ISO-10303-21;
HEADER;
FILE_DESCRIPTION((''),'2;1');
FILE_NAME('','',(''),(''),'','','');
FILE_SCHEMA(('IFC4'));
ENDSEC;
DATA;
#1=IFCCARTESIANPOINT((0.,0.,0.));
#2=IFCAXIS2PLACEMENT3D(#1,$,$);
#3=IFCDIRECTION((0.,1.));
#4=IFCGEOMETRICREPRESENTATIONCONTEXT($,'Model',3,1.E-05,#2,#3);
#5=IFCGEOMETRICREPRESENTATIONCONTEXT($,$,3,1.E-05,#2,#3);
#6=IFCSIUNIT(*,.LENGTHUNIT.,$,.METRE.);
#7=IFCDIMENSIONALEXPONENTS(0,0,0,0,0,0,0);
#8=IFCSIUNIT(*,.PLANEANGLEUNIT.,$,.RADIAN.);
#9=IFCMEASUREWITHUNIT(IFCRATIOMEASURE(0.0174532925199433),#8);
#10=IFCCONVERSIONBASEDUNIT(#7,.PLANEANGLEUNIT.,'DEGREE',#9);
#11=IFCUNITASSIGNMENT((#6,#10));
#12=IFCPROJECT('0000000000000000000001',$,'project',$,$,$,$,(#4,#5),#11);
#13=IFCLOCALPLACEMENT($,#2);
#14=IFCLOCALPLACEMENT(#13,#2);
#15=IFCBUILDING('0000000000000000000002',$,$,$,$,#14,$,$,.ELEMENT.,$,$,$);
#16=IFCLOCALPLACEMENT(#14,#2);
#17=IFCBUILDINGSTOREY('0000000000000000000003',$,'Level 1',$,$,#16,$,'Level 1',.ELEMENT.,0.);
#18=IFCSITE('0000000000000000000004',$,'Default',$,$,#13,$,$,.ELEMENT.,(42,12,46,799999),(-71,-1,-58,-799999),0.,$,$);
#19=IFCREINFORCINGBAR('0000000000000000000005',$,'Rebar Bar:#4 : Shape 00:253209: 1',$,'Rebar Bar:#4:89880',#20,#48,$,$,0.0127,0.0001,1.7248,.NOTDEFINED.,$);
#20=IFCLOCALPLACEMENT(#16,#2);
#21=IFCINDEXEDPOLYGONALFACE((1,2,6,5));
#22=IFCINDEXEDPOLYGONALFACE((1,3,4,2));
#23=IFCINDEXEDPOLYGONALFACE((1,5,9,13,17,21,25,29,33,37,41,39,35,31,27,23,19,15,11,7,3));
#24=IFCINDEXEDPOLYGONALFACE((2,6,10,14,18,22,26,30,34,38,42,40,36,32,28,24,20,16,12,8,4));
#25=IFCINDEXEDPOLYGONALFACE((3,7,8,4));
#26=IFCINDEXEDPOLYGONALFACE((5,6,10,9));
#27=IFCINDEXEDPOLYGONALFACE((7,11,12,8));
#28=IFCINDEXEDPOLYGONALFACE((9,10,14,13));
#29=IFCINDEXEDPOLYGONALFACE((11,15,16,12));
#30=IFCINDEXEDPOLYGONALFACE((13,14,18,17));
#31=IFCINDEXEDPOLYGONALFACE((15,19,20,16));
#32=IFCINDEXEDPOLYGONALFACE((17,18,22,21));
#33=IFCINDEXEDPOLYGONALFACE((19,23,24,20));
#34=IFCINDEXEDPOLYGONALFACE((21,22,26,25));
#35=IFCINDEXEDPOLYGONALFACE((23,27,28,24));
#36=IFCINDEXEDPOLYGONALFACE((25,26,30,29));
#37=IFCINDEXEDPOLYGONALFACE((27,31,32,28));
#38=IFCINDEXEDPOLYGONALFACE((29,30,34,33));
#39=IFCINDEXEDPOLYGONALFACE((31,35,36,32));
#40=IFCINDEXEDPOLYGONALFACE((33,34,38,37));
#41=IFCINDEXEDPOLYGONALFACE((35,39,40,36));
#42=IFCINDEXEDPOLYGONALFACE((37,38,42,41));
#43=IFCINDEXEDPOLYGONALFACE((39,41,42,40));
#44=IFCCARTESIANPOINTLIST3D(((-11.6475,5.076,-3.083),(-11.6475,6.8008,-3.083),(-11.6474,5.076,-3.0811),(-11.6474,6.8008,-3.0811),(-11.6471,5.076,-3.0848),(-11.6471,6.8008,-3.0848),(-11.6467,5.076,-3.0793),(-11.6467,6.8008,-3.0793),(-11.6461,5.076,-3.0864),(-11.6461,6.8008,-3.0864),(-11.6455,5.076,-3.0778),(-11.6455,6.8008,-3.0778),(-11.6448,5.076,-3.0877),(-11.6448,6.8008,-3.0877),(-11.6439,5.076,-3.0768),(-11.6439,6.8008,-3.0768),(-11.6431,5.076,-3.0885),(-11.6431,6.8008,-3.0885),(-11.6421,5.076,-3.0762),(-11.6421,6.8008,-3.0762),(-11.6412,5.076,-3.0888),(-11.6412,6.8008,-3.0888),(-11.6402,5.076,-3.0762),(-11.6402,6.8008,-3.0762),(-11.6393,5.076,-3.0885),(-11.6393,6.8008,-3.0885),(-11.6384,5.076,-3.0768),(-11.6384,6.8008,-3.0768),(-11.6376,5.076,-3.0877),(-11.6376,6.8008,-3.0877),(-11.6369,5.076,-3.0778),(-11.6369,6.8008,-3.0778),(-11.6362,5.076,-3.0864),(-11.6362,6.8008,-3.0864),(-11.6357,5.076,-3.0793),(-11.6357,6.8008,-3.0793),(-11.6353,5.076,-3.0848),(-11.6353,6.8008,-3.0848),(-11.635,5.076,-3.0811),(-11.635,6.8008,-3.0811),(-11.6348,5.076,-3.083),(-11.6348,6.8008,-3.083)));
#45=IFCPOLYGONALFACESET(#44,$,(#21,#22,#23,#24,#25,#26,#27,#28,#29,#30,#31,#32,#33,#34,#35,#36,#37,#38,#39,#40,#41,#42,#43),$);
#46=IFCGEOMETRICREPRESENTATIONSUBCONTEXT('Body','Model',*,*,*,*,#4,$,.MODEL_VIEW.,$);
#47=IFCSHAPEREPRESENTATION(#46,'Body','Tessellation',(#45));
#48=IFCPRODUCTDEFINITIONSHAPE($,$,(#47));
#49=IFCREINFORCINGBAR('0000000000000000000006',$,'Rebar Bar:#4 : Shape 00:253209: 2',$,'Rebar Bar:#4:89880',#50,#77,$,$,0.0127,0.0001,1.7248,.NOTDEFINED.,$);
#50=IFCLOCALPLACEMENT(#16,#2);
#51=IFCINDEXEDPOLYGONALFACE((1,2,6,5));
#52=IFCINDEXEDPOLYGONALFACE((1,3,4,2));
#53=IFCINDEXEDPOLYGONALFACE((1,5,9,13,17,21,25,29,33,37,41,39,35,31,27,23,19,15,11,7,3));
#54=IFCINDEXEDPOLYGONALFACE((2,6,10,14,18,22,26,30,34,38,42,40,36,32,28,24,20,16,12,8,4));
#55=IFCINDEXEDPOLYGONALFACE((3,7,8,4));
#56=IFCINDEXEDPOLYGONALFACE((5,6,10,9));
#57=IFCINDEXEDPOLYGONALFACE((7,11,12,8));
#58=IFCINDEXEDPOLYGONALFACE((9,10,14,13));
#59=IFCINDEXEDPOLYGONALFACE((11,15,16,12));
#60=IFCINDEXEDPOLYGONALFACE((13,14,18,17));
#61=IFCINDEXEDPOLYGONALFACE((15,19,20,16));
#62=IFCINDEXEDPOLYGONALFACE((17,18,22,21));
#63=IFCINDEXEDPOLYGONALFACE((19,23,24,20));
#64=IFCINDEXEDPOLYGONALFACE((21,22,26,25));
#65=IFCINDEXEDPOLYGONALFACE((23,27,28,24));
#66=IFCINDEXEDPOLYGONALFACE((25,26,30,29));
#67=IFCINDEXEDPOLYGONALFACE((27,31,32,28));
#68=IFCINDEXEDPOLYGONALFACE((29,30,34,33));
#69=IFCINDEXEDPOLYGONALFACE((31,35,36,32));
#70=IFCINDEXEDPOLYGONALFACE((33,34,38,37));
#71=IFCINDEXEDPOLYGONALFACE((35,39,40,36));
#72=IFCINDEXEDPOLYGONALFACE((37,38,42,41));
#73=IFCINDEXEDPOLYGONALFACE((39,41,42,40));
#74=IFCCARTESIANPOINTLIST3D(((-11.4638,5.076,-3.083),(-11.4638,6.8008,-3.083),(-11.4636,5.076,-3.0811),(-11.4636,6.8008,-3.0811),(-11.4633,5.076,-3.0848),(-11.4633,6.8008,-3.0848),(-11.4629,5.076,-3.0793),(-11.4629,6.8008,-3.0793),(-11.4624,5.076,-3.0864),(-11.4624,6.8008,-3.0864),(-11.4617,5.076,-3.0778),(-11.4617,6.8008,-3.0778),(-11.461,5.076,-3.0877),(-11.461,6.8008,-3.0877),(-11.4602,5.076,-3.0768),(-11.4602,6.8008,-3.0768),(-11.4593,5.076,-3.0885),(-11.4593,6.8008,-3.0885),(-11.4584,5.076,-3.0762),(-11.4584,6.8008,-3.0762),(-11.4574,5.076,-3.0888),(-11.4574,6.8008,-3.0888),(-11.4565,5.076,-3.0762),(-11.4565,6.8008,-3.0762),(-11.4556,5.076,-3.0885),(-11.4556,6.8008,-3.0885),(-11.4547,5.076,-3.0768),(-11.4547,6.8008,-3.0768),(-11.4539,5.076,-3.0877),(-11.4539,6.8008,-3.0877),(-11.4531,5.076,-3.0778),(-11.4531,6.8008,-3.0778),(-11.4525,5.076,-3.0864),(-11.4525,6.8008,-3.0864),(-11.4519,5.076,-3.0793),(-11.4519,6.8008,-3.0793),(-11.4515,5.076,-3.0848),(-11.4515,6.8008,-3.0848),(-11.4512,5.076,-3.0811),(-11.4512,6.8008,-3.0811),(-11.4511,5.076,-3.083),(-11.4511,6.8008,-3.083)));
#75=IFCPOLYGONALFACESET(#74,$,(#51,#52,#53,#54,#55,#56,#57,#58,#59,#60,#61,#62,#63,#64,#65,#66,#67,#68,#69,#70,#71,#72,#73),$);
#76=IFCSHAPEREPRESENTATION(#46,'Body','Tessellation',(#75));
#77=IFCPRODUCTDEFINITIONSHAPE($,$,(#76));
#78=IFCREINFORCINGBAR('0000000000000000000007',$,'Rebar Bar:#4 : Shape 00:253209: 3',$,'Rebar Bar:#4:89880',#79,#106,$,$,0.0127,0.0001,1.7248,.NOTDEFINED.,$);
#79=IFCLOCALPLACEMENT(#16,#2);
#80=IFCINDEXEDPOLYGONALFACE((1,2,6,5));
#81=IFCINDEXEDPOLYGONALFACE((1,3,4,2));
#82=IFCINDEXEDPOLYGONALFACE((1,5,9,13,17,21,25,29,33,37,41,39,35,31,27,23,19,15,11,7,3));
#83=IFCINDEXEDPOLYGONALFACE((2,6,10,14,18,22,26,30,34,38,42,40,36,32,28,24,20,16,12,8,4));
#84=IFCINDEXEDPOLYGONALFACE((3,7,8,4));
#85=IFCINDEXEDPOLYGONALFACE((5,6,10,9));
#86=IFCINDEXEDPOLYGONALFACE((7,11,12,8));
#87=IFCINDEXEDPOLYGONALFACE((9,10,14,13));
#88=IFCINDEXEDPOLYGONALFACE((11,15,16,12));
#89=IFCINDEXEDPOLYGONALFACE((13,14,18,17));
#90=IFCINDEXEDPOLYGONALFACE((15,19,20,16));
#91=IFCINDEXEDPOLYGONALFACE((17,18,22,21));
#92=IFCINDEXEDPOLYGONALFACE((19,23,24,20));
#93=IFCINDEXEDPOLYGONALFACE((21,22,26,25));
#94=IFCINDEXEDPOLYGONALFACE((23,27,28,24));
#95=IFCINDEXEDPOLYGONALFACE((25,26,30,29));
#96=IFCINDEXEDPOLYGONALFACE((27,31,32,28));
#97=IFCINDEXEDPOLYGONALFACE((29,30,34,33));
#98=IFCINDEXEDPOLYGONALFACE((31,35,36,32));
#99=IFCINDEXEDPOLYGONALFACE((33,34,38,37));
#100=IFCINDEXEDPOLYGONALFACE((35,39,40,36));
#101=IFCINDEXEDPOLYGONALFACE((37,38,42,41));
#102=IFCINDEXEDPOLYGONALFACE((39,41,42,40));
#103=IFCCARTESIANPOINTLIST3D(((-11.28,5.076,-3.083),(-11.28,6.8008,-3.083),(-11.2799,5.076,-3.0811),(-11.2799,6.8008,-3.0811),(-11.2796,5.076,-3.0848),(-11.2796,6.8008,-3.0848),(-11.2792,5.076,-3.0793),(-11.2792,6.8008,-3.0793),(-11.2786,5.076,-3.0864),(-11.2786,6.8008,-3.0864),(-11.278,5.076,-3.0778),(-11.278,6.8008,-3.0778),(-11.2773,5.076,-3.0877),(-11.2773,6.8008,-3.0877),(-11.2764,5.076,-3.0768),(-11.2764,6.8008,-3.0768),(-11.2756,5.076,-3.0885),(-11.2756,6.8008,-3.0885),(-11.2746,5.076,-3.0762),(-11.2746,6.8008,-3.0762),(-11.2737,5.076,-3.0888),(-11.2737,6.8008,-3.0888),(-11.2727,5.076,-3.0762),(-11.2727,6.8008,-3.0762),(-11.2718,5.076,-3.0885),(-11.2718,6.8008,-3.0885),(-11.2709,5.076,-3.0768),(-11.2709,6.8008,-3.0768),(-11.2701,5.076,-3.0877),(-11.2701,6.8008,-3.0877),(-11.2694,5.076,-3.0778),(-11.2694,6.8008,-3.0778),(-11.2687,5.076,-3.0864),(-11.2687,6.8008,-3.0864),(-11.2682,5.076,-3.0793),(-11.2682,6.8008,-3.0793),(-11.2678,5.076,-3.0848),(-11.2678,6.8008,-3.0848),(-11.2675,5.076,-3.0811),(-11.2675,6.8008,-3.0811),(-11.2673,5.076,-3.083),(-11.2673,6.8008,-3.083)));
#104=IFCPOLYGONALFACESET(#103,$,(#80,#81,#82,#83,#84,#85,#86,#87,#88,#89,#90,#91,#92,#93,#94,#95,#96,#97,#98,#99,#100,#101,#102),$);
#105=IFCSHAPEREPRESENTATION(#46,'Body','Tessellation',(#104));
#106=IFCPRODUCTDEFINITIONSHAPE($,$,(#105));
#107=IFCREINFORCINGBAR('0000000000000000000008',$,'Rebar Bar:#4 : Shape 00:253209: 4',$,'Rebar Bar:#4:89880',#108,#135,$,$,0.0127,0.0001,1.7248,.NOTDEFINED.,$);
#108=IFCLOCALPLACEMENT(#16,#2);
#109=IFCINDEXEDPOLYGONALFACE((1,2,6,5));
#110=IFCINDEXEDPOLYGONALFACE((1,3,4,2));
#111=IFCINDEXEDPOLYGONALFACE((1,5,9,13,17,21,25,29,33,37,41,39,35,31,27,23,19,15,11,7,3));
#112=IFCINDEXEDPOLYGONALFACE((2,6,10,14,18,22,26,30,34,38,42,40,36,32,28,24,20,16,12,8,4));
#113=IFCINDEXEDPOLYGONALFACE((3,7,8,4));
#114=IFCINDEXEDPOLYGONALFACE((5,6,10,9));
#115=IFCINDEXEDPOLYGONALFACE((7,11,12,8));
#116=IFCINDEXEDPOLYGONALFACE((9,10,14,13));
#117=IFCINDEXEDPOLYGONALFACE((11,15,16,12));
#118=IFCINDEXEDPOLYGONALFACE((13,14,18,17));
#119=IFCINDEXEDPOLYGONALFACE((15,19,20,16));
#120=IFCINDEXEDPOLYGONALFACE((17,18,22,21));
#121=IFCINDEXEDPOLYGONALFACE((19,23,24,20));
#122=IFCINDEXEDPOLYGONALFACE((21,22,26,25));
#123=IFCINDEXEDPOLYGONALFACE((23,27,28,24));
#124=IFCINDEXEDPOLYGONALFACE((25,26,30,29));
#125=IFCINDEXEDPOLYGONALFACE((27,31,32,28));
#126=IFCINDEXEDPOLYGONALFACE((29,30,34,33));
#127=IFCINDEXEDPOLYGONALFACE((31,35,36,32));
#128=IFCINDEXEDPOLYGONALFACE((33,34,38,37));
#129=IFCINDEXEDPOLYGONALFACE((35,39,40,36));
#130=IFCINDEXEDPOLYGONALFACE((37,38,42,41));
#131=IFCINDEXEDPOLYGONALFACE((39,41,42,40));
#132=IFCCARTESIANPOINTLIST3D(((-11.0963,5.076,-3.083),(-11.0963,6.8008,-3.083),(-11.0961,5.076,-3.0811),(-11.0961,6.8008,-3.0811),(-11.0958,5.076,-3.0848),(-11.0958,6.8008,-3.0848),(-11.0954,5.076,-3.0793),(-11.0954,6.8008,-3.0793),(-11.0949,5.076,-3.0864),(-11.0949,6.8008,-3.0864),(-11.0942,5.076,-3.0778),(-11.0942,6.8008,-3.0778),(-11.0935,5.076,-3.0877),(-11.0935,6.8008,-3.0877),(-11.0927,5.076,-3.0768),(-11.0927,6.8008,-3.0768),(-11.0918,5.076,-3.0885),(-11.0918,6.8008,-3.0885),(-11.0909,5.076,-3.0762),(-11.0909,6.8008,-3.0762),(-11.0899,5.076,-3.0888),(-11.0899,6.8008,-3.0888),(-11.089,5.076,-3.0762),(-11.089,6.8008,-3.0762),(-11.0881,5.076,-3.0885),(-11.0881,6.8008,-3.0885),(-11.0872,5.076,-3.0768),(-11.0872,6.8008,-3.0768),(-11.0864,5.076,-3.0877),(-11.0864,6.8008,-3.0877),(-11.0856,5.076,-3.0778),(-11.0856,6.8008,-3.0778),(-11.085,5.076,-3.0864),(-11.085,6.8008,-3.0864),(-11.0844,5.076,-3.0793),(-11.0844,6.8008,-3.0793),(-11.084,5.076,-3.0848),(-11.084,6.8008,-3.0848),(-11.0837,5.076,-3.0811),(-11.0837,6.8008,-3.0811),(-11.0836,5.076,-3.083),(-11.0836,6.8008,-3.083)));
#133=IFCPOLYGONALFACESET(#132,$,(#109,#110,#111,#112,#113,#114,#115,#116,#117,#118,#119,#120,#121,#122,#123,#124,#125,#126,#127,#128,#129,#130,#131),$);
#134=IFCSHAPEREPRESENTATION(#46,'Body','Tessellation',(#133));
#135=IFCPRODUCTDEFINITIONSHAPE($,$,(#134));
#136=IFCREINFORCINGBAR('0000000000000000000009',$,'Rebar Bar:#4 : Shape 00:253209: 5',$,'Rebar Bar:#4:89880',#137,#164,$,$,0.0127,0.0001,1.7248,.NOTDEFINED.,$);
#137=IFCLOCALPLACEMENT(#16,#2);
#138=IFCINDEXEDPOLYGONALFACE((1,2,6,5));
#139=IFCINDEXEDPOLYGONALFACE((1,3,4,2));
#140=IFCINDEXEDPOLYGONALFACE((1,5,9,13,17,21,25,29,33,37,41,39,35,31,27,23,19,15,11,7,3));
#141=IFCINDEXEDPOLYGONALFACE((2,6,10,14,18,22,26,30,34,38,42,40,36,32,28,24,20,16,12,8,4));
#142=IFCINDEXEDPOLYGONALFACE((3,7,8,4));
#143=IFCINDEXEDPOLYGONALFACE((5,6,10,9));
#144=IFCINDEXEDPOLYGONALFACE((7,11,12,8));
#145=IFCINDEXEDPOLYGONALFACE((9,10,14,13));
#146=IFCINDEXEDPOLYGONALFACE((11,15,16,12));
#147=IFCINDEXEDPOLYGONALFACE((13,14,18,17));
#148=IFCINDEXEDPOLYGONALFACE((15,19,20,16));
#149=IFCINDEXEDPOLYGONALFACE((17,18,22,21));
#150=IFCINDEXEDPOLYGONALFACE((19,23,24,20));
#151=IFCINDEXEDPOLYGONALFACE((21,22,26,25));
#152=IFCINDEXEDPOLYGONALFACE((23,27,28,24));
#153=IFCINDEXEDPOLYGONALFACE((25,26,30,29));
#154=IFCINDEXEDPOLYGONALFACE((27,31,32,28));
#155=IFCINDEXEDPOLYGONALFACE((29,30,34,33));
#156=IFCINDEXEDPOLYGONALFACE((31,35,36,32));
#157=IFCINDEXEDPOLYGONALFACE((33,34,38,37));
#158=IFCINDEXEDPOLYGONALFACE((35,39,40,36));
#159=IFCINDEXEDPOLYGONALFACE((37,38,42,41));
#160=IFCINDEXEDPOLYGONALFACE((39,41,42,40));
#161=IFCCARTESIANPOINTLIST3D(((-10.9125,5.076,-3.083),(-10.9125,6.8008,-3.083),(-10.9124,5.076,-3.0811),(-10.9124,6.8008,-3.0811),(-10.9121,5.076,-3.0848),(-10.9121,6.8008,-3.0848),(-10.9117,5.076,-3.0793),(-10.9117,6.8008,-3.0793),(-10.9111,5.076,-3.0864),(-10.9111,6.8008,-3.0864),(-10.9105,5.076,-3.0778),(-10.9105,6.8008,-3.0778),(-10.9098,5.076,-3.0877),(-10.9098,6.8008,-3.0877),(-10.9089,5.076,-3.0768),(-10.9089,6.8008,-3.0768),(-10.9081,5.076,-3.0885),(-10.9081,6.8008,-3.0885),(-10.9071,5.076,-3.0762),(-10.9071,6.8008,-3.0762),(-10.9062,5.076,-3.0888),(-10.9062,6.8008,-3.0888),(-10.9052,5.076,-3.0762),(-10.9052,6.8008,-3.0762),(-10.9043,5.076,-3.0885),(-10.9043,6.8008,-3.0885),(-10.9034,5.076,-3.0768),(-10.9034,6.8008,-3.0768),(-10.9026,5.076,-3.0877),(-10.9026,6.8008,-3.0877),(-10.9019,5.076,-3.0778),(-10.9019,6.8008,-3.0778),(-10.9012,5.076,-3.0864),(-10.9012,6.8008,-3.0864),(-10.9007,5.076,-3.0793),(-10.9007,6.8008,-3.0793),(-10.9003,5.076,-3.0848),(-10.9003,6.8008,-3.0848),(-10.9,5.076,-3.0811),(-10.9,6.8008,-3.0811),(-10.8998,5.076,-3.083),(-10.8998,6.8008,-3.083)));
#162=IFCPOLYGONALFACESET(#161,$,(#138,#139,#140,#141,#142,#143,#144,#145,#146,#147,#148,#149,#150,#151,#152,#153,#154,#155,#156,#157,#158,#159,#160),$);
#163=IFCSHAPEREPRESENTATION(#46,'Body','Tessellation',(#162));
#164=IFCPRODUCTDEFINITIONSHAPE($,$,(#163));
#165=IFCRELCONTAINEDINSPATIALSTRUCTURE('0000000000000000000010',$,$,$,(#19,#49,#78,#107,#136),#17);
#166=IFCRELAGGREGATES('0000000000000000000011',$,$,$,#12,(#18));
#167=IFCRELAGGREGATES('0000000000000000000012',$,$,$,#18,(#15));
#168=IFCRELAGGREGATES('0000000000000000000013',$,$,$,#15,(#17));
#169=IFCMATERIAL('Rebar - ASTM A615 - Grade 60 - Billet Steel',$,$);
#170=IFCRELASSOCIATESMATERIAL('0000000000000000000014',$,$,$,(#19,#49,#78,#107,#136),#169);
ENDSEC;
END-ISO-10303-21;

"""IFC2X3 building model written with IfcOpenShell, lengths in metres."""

from ifc_helpers import new_model, entity, si_unit, converted_unit, direction, origin, place, context, subcontext, project, spatial, material, element, save


model = new_model("IFC2X3")

# Units and contexts
model_context = context("Model", 3, precision=1e-05, world=origin(), true_north=direction((0.0, 1.0)))
context_of_model = context(None, 3, precision=1e-05, world=origin(), true_north=direction((0.0, 1.0)))
body_context = subcontext(model_context, "Body", "Model", "MODEL_VIEW")
ifc_project = project(units=[si_unit("LENGTHUNIT", "METRE"), converted_unit("PLANEANGLEUNIT", "DEGREE", entity("IfcRatioMeasure", 0.0174532925199433), si_unit("PLANEANGLEUNIT", "RADIAN"), dimensions=[0, 0, 0, 0, 0, 0, 0])], contexts=[model_context, context_of_model])

# Site, building, storey
site_placement = place(None, origin())
site = spatial("IfcSite", under=ifc_project, at=site_placement, Name="Default", CompositionType="ELEMENT", RefLatitude=(42, 12, 46, 799999), RefLongitude=(-71, -1, -58, -799999), RefElevation=0.0)
building_placement = place(site_placement, origin())
building = spatial("IfcBuilding", under=site, at=building_placement, CompositionType="ELEMENT")
storey_placement = place(building_placement, origin())
storey = spatial("IfcBuildingStorey", under=building, at=storey_placement, Name="Level 1", LongName="Level 1", CompositionType="ELEMENT", Elevation=0.0)

# Reinforcing bars
ifc_material = material(Name="Rebar - ASTM A615 - Grade 60 - Billet Steel")
reinforcing_bar_1_placement = place(storey_placement, origin())
element("IfcReinforcingBar", 1, at=reinforcing_bar_1_placement, inside=storey, material=ifc_material, Name="Rebar Bar:#4 : Shape 00:253209: 1", ObjectType="Rebar Bar:#4:89880", BarLength=1.7248, BarRole="NOTDEFINED", CrossSectionArea=0.0001, NominalDiameter=0.0127, context=body_context, shape_type="AdvancedSweptSolid", body=[
    entity("IfcSweptDiskSolid", entity("IfcCompositeCurve", [entity("IfcCompositeCurveSegment", "CONTINUOUS", True, entity("IfcPolyline", [entity("IfcCartesianPoint", [-11.6412, 6.8008, -3.0825]), entity("IfcCartesianPoint", [-11.6412, 5.076, -3.0825])]))], False), 0.0063, None, 0.0, 1.0),
])
reinforcing_bar_2_placement = place(storey_placement, origin())
element("IfcReinforcingBar", 2, at=reinforcing_bar_2_placement, inside=storey, material=ifc_material, Name="Rebar Bar:#4 : Shape 00:253209: 2", ObjectType="Rebar Bar:#4:89880", BarLength=1.7248, BarRole="NOTDEFINED", CrossSectionArea=0.0001, NominalDiameter=0.0127, context=body_context, shape_type="AdvancedSweptSolid", body=[
    entity("IfcSweptDiskSolid", entity("IfcCompositeCurve", [entity("IfcCompositeCurveSegment", "CONTINUOUS", True, entity("IfcPolyline", [entity("IfcCartesianPoint", [-11.4574, 6.8008, -3.0825]), entity("IfcCartesianPoint", [-11.4574, 5.076, -3.0825])]))], False), 0.0063, None, 0.0, 1.0),
])
reinforcing_bar_3_placement = place(storey_placement, origin())
element("IfcReinforcingBar", 3, at=reinforcing_bar_3_placement, inside=storey, material=ifc_material, Name="Rebar Bar:#4 : Shape 00:253209: 3", ObjectType="Rebar Bar:#4:89880", BarLength=1.7248, BarRole="NOTDEFINED", CrossSectionArea=0.0001, NominalDiameter=0.0127, context=body_context, shape_type="AdvancedSweptSolid", body=[
    entity("IfcSweptDiskSolid", entity("IfcCompositeCurve", [entity("IfcCompositeCurveSegment", "CONTINUOUS", True, entity("IfcPolyline", [entity("IfcCartesianPoint", [-11.2737, 6.8008, -3.0825]), entity("IfcCartesianPoint", [-11.2737, 5.076, -3.0825])]))], False), 0.0063, None, 0.0, 1.0),
])
reinforcing_bar_4_placement = place(storey_placement, origin())
element("IfcReinforcingBar", 4, at=reinforcing_bar_4_placement, inside=storey, material=ifc_material, Name="Rebar Bar:#4 : Shape 00:253209: 4", ObjectType="Rebar Bar:#4:89880", BarLength=1.7248, BarRole="NOTDEFINED", CrossSectionArea=0.0001, NominalDiameter=0.0127, context=body_context, shape_type="AdvancedSweptSolid", body=[
    entity("IfcSweptDiskSolid", entity("IfcCompositeCurve", [entity("IfcCompositeCurveSegment", "CONTINUOUS", True, entity("IfcPolyline", [entity("IfcCartesianPoint", [-11.0899, 6.8008, -3.0825]), entity("IfcCartesianPoint", [-11.0899, 5.076, -3.0825])]))], False), 0.0063, None, 0.0, 1.0),
])
reinforcing_bar_5_placement = place(storey_placement, origin())
element("IfcReinforcingBar", 5, at=reinforcing_bar_5_placement, inside=storey, material=ifc_material, Name="Rebar Bar:#4 : Shape 00:253209: 5", ObjectType="Rebar Bar:#4:89880", BarLength=1.7248, BarRole="NOTDEFINED", CrossSectionArea=0.0001, NominalDiameter=0.0127, context=body_context, shape_type="AdvancedSweptSolid", body=[
    entity("IfcSweptDiskSolid", entity("IfcCompositeCurve", [entity("IfcCompositeCurveSegment", "CONTINUOUS", True, entity("IfcPolyline", [entity("IfcCartesianPoint", [-10.9062, 6.8008, -3.0825]), entity("IfcCartesianPoint", [-10.9062, 5.076, -3.0825])]))], False), 0.0063, None, 0.0, 1.0),
])

save(model, "model.ifc")
